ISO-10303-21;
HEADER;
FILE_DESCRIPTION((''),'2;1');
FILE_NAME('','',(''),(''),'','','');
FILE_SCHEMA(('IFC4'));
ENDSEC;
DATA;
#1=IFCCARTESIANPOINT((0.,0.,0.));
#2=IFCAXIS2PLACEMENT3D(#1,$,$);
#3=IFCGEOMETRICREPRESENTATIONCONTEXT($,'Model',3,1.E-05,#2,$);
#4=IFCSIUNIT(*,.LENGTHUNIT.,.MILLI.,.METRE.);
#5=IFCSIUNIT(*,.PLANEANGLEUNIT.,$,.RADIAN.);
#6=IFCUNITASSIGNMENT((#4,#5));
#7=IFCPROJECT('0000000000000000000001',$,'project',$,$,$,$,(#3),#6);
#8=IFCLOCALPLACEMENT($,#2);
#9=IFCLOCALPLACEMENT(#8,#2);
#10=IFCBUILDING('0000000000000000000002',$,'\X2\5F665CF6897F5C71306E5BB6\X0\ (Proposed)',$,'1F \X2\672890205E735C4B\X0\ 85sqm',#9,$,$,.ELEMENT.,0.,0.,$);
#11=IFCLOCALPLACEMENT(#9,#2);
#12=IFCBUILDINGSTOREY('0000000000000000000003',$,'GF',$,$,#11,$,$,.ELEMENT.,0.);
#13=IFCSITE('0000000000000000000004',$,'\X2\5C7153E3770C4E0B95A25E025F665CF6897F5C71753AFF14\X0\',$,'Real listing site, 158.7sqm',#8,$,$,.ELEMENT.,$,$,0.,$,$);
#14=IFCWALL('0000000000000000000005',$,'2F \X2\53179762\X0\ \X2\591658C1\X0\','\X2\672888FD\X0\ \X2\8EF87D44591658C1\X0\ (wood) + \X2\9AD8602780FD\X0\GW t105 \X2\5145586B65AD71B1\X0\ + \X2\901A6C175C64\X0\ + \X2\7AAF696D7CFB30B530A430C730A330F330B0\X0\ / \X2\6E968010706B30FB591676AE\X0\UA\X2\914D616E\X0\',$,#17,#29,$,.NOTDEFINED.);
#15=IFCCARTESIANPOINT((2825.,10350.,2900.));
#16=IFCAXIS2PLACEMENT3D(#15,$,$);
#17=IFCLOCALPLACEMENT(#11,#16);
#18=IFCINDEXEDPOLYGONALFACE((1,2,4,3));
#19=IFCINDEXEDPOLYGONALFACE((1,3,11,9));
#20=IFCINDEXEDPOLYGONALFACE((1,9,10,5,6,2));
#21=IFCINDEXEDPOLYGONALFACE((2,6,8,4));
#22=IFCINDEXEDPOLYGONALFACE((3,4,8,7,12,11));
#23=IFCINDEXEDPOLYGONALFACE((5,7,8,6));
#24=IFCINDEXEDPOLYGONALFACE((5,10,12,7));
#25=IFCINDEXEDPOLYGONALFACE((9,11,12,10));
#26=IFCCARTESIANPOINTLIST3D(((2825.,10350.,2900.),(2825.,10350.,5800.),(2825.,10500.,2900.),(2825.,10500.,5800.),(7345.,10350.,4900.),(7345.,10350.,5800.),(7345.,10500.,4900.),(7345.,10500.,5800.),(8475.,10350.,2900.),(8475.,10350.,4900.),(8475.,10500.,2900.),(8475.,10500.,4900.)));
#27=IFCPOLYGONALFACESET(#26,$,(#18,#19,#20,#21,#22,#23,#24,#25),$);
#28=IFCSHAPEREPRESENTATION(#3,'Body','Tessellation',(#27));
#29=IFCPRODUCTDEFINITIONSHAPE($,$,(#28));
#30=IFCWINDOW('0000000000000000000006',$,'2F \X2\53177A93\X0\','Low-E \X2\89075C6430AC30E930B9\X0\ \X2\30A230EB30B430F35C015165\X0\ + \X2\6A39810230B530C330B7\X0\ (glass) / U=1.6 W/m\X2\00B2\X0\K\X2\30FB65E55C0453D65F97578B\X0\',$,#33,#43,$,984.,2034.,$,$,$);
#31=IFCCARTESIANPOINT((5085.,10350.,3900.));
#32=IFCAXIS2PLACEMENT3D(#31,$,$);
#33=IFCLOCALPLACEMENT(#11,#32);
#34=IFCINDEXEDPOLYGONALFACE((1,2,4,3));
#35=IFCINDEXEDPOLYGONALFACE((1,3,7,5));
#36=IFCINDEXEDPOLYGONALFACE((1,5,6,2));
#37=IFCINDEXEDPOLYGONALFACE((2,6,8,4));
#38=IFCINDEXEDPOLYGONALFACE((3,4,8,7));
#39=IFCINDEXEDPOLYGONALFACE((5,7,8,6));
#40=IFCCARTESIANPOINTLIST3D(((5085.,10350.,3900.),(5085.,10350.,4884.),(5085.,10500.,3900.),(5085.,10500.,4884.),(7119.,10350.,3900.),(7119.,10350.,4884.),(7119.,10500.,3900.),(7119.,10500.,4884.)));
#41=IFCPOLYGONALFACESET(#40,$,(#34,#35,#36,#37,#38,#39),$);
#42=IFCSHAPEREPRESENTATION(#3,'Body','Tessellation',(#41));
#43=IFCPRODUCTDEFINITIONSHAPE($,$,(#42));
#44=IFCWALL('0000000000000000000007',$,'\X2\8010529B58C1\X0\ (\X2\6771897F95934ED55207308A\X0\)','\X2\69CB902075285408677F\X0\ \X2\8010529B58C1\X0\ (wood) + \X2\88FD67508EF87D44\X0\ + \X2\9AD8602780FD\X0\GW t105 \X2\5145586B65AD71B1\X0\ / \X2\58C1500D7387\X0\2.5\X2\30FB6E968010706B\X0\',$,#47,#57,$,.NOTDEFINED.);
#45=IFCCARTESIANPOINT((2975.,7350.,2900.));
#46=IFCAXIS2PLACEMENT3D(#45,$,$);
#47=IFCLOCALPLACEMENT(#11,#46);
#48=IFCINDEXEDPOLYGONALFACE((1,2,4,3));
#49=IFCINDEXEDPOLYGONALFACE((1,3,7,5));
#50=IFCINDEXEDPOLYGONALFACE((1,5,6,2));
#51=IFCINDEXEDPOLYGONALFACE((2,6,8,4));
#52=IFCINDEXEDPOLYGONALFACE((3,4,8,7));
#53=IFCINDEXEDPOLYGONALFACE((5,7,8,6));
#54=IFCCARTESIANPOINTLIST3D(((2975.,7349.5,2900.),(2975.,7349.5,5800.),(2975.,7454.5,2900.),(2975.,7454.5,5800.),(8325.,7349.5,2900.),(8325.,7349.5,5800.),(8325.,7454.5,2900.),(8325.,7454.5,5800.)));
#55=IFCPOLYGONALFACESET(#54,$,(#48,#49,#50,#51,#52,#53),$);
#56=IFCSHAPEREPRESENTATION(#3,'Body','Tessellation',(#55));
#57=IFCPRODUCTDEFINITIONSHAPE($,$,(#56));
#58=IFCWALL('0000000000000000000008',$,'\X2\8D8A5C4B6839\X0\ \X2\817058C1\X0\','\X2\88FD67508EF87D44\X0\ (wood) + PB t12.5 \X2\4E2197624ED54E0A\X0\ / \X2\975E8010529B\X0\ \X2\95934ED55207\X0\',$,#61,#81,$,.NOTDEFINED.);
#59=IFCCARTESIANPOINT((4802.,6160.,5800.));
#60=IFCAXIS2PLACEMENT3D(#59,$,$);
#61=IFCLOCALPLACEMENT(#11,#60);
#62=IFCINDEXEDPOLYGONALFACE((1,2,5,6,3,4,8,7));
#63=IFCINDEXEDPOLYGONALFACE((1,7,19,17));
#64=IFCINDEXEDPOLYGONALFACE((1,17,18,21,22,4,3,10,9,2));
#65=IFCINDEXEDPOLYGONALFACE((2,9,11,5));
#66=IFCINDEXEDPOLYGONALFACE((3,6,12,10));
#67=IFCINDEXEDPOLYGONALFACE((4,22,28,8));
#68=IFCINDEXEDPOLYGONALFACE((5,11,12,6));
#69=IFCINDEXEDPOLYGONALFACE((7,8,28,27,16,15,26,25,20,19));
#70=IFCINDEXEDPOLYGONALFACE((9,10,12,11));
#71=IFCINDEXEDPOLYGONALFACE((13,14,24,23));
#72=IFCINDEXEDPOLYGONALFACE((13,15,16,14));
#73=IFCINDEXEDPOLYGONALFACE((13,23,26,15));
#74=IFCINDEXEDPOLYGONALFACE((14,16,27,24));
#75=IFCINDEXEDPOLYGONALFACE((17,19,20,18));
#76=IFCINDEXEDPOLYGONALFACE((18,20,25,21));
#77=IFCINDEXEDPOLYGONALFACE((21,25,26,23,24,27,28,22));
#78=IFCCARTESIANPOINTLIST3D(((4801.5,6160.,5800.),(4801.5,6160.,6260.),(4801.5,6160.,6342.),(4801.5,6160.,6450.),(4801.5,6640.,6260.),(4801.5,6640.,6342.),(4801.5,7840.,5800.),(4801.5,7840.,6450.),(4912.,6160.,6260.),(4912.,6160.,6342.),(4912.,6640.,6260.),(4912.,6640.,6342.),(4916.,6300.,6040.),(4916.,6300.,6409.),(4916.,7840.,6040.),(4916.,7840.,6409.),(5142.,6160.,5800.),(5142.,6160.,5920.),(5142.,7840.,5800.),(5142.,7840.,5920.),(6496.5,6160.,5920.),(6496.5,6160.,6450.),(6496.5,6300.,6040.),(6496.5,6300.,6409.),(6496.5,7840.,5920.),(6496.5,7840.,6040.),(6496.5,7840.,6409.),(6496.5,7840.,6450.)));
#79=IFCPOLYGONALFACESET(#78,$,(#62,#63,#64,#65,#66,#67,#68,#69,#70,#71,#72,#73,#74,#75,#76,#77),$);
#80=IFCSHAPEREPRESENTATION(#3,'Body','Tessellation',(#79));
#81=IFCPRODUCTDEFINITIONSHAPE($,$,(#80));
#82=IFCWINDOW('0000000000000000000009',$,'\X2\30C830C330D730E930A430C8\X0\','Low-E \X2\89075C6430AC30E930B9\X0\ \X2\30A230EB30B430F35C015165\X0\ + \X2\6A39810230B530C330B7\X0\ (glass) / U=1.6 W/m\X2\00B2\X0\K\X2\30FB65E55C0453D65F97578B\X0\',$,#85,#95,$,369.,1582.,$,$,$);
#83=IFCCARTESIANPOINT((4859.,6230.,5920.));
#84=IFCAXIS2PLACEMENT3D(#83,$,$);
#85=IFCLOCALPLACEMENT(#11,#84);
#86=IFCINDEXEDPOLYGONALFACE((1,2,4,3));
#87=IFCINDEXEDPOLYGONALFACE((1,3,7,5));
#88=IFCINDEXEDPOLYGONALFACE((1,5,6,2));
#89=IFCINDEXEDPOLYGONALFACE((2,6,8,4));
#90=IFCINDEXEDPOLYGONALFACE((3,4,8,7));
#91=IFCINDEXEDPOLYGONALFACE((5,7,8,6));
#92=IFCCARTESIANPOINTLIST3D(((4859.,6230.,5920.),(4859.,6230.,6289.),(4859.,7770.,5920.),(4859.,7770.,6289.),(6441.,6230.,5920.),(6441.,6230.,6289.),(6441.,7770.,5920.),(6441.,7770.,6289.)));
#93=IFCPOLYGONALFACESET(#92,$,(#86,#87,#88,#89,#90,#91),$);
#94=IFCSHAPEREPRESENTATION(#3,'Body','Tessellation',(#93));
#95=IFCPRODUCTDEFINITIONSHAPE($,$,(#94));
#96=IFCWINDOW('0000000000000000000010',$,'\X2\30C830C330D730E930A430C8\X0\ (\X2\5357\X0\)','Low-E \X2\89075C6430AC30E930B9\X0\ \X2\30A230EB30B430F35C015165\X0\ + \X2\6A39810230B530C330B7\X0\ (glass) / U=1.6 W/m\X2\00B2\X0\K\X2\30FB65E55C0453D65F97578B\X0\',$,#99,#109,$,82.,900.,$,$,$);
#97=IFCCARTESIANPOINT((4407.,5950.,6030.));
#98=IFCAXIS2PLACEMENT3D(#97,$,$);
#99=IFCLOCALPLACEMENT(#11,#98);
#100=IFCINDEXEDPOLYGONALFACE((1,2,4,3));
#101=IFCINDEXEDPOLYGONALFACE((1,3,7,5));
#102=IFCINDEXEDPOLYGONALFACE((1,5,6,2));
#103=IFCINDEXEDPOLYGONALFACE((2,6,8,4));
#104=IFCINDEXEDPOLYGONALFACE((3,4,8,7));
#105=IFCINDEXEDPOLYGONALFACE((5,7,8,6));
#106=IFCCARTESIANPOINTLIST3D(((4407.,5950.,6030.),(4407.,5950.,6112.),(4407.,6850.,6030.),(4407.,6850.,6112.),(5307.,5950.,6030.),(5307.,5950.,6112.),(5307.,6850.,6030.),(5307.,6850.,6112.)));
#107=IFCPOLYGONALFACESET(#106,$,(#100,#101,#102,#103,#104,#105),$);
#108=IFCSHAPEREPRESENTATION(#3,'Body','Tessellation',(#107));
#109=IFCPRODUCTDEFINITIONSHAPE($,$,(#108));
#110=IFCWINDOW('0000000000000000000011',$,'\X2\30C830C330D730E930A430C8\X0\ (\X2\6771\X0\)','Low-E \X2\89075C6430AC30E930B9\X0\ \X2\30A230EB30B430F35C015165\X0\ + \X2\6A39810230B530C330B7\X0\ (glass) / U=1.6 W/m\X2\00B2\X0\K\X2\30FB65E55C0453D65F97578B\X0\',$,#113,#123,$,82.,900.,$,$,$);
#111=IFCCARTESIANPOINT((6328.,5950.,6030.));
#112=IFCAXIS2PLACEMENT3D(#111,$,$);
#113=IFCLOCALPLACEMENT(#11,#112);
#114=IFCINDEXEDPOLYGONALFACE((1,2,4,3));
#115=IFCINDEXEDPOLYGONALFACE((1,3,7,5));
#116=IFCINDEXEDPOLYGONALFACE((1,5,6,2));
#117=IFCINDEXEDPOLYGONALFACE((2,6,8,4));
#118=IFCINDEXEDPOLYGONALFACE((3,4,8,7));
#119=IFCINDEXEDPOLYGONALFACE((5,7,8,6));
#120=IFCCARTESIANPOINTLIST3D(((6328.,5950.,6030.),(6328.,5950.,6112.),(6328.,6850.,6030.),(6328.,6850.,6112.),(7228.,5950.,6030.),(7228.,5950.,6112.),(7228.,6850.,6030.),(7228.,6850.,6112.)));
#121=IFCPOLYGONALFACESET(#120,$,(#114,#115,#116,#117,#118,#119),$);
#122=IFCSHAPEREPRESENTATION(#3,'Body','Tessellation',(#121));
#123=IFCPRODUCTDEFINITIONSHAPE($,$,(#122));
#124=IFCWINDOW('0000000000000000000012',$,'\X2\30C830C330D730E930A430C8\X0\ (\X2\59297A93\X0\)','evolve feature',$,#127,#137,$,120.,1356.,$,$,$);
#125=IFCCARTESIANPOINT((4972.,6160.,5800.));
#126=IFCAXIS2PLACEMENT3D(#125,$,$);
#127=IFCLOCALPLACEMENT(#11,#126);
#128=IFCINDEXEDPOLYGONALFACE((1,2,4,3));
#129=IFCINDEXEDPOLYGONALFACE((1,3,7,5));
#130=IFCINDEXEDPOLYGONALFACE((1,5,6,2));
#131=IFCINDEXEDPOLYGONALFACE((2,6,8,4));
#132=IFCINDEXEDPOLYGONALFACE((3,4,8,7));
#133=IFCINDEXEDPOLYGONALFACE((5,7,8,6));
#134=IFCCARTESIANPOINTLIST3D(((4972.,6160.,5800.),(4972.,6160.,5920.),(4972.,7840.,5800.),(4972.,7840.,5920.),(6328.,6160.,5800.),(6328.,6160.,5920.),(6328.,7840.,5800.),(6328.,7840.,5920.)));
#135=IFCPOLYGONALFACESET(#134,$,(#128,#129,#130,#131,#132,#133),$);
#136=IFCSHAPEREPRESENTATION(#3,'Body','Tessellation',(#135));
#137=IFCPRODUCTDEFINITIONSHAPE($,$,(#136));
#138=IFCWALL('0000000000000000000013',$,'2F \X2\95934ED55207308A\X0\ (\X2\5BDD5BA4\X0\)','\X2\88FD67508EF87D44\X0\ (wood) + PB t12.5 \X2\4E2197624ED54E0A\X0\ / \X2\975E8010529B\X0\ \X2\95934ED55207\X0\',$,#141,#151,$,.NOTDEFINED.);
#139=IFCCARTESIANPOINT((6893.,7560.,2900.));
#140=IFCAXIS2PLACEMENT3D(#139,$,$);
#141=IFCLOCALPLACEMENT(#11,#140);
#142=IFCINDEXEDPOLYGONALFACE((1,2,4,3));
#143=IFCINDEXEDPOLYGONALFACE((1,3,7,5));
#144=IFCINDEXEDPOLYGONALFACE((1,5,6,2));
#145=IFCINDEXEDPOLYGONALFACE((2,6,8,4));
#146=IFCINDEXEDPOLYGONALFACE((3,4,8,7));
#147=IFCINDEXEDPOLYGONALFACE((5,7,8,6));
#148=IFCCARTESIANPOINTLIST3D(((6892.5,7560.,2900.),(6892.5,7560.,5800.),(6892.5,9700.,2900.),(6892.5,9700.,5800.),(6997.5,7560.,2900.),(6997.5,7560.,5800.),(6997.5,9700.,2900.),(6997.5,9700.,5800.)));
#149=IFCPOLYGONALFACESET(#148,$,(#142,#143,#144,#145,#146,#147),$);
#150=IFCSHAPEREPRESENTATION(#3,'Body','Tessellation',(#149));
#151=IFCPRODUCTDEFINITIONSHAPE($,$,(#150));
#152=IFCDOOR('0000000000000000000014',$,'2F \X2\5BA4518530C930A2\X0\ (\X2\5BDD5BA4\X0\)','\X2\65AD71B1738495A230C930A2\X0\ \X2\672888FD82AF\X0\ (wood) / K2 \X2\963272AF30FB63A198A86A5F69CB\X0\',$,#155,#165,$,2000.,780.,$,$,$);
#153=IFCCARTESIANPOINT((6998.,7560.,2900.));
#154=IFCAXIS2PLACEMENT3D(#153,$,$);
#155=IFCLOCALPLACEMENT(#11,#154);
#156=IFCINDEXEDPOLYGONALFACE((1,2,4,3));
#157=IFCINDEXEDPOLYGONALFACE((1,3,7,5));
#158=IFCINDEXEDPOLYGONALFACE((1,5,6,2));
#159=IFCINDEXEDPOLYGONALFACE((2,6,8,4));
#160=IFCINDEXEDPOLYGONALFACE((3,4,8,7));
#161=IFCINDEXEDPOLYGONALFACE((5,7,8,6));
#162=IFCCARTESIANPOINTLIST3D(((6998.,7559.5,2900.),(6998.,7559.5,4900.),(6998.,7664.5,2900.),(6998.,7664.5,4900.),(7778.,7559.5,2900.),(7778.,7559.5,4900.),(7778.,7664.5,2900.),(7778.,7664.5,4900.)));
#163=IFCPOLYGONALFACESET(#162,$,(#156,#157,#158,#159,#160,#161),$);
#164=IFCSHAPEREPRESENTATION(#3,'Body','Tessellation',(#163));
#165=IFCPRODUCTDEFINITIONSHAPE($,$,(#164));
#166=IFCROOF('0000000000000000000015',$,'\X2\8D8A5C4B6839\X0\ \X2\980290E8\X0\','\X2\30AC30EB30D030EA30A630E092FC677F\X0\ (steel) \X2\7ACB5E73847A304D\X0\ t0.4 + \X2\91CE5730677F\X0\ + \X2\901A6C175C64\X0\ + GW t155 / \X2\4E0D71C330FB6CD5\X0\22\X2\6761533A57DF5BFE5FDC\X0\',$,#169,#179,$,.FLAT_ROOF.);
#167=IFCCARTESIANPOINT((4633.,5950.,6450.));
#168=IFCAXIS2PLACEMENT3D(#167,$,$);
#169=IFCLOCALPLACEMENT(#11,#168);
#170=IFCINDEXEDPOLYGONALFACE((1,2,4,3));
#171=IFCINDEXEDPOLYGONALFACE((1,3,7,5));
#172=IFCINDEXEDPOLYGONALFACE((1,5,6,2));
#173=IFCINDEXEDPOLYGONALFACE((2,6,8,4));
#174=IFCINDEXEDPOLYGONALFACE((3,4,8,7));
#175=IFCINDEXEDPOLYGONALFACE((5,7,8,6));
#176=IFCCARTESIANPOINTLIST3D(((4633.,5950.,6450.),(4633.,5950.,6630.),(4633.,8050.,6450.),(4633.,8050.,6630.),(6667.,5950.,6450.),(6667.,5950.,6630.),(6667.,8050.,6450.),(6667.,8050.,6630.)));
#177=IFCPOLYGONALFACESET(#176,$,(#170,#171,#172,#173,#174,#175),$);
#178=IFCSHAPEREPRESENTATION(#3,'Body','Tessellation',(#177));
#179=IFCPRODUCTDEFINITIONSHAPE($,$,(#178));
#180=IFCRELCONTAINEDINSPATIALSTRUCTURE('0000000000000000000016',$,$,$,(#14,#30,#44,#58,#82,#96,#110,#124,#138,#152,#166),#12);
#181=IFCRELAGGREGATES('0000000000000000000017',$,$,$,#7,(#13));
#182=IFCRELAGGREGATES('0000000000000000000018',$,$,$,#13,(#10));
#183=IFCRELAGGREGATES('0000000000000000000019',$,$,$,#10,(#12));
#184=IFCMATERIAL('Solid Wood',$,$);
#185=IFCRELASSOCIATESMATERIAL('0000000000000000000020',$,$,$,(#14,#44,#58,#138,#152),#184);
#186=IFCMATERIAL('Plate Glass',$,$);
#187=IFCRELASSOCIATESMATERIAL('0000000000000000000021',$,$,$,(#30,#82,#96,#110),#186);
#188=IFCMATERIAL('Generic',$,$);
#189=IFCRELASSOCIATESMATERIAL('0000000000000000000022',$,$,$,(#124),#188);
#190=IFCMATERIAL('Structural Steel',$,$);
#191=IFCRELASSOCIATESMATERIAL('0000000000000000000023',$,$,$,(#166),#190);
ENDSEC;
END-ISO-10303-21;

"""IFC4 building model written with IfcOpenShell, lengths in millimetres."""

from ifc_helpers import new_model, si_unit, frame, frame_2d, origin, place, context, project, spatial, rectangle, extrude, material, element, fill, save


model = new_model("IFC4")

# Units and contexts
model_context = context("Model", 3, precision=1e-05, world=origin())
ifc_project = project(units=[si_unit("LENGTHUNIT", "METRE", prefix="MILLI"), si_unit("PLANEANGLEUNIT", "RADIAN")], contexts=[model_context])

# Site, building, storey
site_placement = place(None, origin())
site = spatial("IfcSite", under=ifc_project, at=site_placement, Name="山口県下関市彦島西山町４", ObjectType="Real listing site, 158.7sqm", CompositionType="ELEMENT", RefElevation=0.0)
building_placement = place(site_placement, origin())
building = spatial("IfcBuilding", under=site, at=building_placement, Name="彦島西山の家 (Proposed)", ObjectType="1F 木造平屋 85sqm", CompositionType="ELEMENT", ElevationOfRefHeight=0.0, ElevationOfTerrain=0.0)
storey_placement = place(building_placement, origin())
storey = spatial("IfcBuildingStorey", under=building, at=storey_placement, Name="GF", CompositionType="ELEMENT", Elevation=0.0)

# Wall, opening, window
ifc_material_1 = material(Name="Solid Wood")
wall_1_placement = place(storey_placement, frame((2825.0, 10350.0, 2900.0)))
wall_1 = element("IfcWall", 1, at=wall_1_placement, inside=storey, material=ifc_material_1, Name="2F 北面 外壁", Description="木製 軸組外壁 (wood) + 高性能GW t105 充填断熱 + 通気層 + 窯業系サイディング / 準耐火・外皮UA配慮", PredefinedType="NOTDEFINED", context=model_context, shape_type="SweptSolid", body=[
    extrude(rectangle(XDim=5650.0, YDim=150.0, at=frame_2d((2825.0, 75.0))), frame((2825.0, 10350.0, 2900.0)), (0.0, 0.0, 1.0), 2900.0),
])
opening_1_placement = place(storey_placement, frame((5085.0, 10350.0, 3900.0)))
opening_1 = element("IfcOpeningElement", 2, at=opening_1_placement, cuts=wall_1, PredefinedType="NOTDEFINED", context=model_context, shape_type="SweptSolid", body=[
    extrude(rectangle(XDim=2034.0, YDim=150.0, at=frame_2d((1017.0, 75.0))), frame((5085.0, 10350.0, 3900.0)), (0.0, 0.0, 1.0), 984.0),
])
ifc_material_2 = material(Name="Plate Glass")
window_1_placement = place(storey_placement, frame((5085.0, 10350.0, 3900.0)))
window_1 = element("IfcWindow", 3, at=window_1_placement, inside=storey, material=ifc_material_2, Name="2F 北窓", Description="Low-E 複層ガラス アルゴン封入 + 樹脂サッシ (glass) / U=1.6 W/m²K・日射取得型", OverallHeight=984.0, OverallWidth=2034.0, context=model_context, shape_type="SweptSolid", body=[
    extrude(rectangle(XDim=2034.0, YDim=150.0, at=frame_2d((1017.0, 75.0))), frame((5085.0, 10350.0, 3900.0)), (0.0, 0.0, 1.0), 984.0),
])
fill(opening_1, window_1)

# Wall
wall_2_placement = place(storey_placement, frame((2975.0, 7350.0, 2900.0)))
element("IfcWall", 4, at=wall_2_placement, inside=storey, material=ifc_material_1, Name="耐力壁 (東西間仕切り)", Description="構造用合板 耐力壁 (wood) + 製材軸組 + 高性能GW t105 充填断熱 / 壁倍率2.5・準耐火", PredefinedType="NOTDEFINED", context=model_context, shape_type="SweptSolid", body=[
    extrude(rectangle(XDim=5350.0, YDim=105.0, at=frame_2d((2675.0, 52.0))), frame((2975.0, 7350.0, 2900.0)), (0.0, 0.0, 1.0), 2900.0),
])

# Wall, openings, windows
wall_3_placement = place(storey_placement, frame((4802.0, 6160.0, 5800.0)))
wall_3 = element("IfcWall", 5, at=wall_3_placement, inside=storey, material=ifc_material_1, Name="越屋根 腰壁", Description="製材軸組 (wood) + PB t12.5 両面仕上 / 非耐力 間仕切", PredefinedType="NOTDEFINED", context=model_context, shape_type="SweptSolid", body=[
    extrude(rectangle(XDim=1695.0, YDim=1680.0, at=frame_2d((847.0, 840.0))), frame((4802.0, 6160.0, 5800.0)), (0.0, 0.0, 1.0), 650.0),
])
opening_2_placement = place(storey_placement, frame((4859.0, 6230.0, 5920.0)))
opening_2 = element("IfcOpeningElement", 6, at=opening_2_placement, cuts=wall_3, PredefinedType="NOTDEFINED", context=model_context, shape_type="SweptSolid", body=[
    extrude(rectangle(XDim=1582.0, YDim=1540.0, at=frame_2d((791.0, 770.0))), frame((4859.0, 6230.0, 5920.0)), (0.0, 0.0, 1.0), 369.0),
])
opening_3_placement = place(storey_placement, frame((4407.0, 5950.0, 6030.0)))
opening_3 = element("IfcOpeningElement", 7, at=opening_3_placement, cuts=wall_3, PredefinedType="NOTDEFINED", context=model_context, shape_type="SweptSolid", body=[
    extrude(rectangle(XDim=900.0, YDim=900.0, at=frame_2d((450.0, 450.0))), frame((4407.0, 5950.0, 6030.0)), (0.0, 0.0, 1.0), 82.0),
])
opening_4_placement = place(storey_placement, frame((6328.0, 5950.0, 6030.0)))
opening_4 = element("IfcOpeningElement", 8, at=opening_4_placement, cuts=wall_3, PredefinedType="NOTDEFINED", context=model_context, shape_type="SweptSolid", body=[
    extrude(rectangle(XDim=900.0, YDim=900.0, at=frame_2d((450.0, 450.0))), frame((6328.0, 5950.0, 6030.0)), (0.0, 0.0, 1.0), 82.0),
])
opening_5_placement = place(storey_placement, frame((4972.0, 6160.0, 5800.0)))
opening_5 = element("IfcOpeningElement", 9, at=opening_5_placement, cuts=wall_3, PredefinedType="NOTDEFINED", context=model_context, shape_type="SweptSolid", body=[
    extrude(rectangle(XDim=1356.0, YDim=1680.0, at=frame_2d((678.0, 840.0))), frame((4972.0, 6160.0, 5800.0)), (0.0, 0.0, 1.0), 120.0),
])
window_2_placement = place(storey_placement, frame((4859.0, 6230.0, 5920.0)))
window_2 = element("IfcWindow", 10, at=window_2_placement, inside=storey, material=ifc_material_2, Name="トップライト", Description="Low-E 複層ガラス アルゴン封入 + 樹脂サッシ (glass) / U=1.6 W/m²K・日射取得型", OverallHeight=369.0, OverallWidth=1582.0, context=model_context, shape_type="SweptSolid", body=[
    extrude(rectangle(XDim=1582.0, YDim=1540.0, at=frame_2d((791.0, 770.0))), frame((4859.0, 6230.0, 5920.0)), (0.0, 0.0, 1.0), 369.0),
])
fill(opening_2, window_2)
window_3_placement = place(storey_placement, frame((4407.0, 5950.0, 6030.0)))
window_3 = element("IfcWindow", 11, at=window_3_placement, inside=storey, material=ifc_material_2, Name="トップライト (南)", Description="Low-E 複層ガラス アルゴン封入 + 樹脂サッシ (glass) / U=1.6 W/m²K・日射取得型", OverallHeight=82.0, OverallWidth=900.0, context=model_context, shape_type="SweptSolid", body=[
    extrude(rectangle(XDim=900.0, YDim=900.0, at=frame_2d((450.0, 450.0))), frame((4407.0, 5950.0, 6030.0)), (0.0, 0.0, 1.0), 82.0),
])
fill(opening_3, window_3)
window_4_placement = place(storey_placement, frame((6328.0, 5950.0, 6030.0)))
window_4 = element("IfcWindow", 12, at=window_4_placement, inside=storey, material=ifc_material_2, Name="トップライト (東)", Description="Low-E 複層ガラス アルゴン封入 + 樹脂サッシ (glass) / U=1.6 W/m²K・日射取得型", OverallHeight=82.0, OverallWidth=900.0, context=model_context, shape_type="SweptSolid", body=[
    extrude(rectangle(XDim=900.0, YDim=900.0, at=frame_2d((450.0, 450.0))), frame((6328.0, 5950.0, 6030.0)), (0.0, 0.0, 1.0), 82.0),
])
fill(opening_4, window_4)
ifc_material_3 = material(Name="Generic")
window_5_placement = place(storey_placement, frame((4972.0, 6160.0, 5800.0)))
window_5 = element("IfcWindow", 13, at=window_5_placement, inside=storey, material=ifc_material_3, Name="トップライト (天窓)", Description="evolve feature", OverallHeight=120.0, OverallWidth=1356.0, context=model_context, shape_type="SweptSolid", body=[
    extrude(rectangle(XDim=1356.0, YDim=1680.0, at=frame_2d((678.0, 840.0))), frame((4972.0, 6160.0, 5800.0)), (0.0, 0.0, 1.0), 120.0),
])
fill(opening_5, window_5)

# Wall
wall_4_placement = place(storey_placement, frame((6893.0, 7560.0, 2900.0)))
element("IfcWall", 14, at=wall_4_placement, inside=storey, material=ifc_material_1, Name="2F 間仕切り (寝室)", Description="製材軸組 (wood) + PB t12.5 両面仕上 / 非耐力 間仕切", PredefinedType="NOTDEFINED", context=model_context, shape_type="SweptSolid", body=[
    extrude(rectangle(XDim=105.0, YDim=2140.0, at=frame_2d((52.0, 1070.0))), frame((6893.0, 7560.0, 2900.0)), (0.0, 0.0, 1.0), 2900.0),
])

# Door
door_placement = place(storey_placement, frame((6998.0, 7560.0, 2900.0)))
element("IfcDoor", 15, at=door_placement, inside=storey, material=ifc_material_1, Name="2F 室内ドア (寝室)", Description="断熱玄関ドア 木製芯 (wood) / K2 防犯・採風機構", OverallHeight=2000.0, OverallWidth=780.0, context=model_context, shape_type="SweptSolid", body=[
    extrude(rectangle(XDim=780.0, YDim=105.0, at=frame_2d((390.0, 52.0))), frame((6998.0, 7560.0, 2900.0)), (0.0, 0.0, 1.0), 2000.0),
])

# Roof
ifc_material_4 = material(Name="Structural Steel")
roof_placement = place(storey_placement, frame((4633.0, 5950.0, 6450.0)))
element("IfcRoof", 16, at=roof_placement, inside=storey, material=ifc_material_4, Name="越屋根 頂部", Description="ガルバリウム鋼板 (steel) 立平葺き t0.4 + 野地板 + 通気層 + GW t155 / 不燃・法22条区域対応", PredefinedType="FLAT_ROOF", context=model_context, shape_type="SweptSolid", body=[
    extrude(rectangle(XDim=2034.0, YDim=2100.0, at=frame_2d((1017.0, 1050.0))), frame((4633.0, 5950.0, 6450.0)), (0.0, 0.0, 1.0), 180.0),
])

save(model, "model.ifc")
